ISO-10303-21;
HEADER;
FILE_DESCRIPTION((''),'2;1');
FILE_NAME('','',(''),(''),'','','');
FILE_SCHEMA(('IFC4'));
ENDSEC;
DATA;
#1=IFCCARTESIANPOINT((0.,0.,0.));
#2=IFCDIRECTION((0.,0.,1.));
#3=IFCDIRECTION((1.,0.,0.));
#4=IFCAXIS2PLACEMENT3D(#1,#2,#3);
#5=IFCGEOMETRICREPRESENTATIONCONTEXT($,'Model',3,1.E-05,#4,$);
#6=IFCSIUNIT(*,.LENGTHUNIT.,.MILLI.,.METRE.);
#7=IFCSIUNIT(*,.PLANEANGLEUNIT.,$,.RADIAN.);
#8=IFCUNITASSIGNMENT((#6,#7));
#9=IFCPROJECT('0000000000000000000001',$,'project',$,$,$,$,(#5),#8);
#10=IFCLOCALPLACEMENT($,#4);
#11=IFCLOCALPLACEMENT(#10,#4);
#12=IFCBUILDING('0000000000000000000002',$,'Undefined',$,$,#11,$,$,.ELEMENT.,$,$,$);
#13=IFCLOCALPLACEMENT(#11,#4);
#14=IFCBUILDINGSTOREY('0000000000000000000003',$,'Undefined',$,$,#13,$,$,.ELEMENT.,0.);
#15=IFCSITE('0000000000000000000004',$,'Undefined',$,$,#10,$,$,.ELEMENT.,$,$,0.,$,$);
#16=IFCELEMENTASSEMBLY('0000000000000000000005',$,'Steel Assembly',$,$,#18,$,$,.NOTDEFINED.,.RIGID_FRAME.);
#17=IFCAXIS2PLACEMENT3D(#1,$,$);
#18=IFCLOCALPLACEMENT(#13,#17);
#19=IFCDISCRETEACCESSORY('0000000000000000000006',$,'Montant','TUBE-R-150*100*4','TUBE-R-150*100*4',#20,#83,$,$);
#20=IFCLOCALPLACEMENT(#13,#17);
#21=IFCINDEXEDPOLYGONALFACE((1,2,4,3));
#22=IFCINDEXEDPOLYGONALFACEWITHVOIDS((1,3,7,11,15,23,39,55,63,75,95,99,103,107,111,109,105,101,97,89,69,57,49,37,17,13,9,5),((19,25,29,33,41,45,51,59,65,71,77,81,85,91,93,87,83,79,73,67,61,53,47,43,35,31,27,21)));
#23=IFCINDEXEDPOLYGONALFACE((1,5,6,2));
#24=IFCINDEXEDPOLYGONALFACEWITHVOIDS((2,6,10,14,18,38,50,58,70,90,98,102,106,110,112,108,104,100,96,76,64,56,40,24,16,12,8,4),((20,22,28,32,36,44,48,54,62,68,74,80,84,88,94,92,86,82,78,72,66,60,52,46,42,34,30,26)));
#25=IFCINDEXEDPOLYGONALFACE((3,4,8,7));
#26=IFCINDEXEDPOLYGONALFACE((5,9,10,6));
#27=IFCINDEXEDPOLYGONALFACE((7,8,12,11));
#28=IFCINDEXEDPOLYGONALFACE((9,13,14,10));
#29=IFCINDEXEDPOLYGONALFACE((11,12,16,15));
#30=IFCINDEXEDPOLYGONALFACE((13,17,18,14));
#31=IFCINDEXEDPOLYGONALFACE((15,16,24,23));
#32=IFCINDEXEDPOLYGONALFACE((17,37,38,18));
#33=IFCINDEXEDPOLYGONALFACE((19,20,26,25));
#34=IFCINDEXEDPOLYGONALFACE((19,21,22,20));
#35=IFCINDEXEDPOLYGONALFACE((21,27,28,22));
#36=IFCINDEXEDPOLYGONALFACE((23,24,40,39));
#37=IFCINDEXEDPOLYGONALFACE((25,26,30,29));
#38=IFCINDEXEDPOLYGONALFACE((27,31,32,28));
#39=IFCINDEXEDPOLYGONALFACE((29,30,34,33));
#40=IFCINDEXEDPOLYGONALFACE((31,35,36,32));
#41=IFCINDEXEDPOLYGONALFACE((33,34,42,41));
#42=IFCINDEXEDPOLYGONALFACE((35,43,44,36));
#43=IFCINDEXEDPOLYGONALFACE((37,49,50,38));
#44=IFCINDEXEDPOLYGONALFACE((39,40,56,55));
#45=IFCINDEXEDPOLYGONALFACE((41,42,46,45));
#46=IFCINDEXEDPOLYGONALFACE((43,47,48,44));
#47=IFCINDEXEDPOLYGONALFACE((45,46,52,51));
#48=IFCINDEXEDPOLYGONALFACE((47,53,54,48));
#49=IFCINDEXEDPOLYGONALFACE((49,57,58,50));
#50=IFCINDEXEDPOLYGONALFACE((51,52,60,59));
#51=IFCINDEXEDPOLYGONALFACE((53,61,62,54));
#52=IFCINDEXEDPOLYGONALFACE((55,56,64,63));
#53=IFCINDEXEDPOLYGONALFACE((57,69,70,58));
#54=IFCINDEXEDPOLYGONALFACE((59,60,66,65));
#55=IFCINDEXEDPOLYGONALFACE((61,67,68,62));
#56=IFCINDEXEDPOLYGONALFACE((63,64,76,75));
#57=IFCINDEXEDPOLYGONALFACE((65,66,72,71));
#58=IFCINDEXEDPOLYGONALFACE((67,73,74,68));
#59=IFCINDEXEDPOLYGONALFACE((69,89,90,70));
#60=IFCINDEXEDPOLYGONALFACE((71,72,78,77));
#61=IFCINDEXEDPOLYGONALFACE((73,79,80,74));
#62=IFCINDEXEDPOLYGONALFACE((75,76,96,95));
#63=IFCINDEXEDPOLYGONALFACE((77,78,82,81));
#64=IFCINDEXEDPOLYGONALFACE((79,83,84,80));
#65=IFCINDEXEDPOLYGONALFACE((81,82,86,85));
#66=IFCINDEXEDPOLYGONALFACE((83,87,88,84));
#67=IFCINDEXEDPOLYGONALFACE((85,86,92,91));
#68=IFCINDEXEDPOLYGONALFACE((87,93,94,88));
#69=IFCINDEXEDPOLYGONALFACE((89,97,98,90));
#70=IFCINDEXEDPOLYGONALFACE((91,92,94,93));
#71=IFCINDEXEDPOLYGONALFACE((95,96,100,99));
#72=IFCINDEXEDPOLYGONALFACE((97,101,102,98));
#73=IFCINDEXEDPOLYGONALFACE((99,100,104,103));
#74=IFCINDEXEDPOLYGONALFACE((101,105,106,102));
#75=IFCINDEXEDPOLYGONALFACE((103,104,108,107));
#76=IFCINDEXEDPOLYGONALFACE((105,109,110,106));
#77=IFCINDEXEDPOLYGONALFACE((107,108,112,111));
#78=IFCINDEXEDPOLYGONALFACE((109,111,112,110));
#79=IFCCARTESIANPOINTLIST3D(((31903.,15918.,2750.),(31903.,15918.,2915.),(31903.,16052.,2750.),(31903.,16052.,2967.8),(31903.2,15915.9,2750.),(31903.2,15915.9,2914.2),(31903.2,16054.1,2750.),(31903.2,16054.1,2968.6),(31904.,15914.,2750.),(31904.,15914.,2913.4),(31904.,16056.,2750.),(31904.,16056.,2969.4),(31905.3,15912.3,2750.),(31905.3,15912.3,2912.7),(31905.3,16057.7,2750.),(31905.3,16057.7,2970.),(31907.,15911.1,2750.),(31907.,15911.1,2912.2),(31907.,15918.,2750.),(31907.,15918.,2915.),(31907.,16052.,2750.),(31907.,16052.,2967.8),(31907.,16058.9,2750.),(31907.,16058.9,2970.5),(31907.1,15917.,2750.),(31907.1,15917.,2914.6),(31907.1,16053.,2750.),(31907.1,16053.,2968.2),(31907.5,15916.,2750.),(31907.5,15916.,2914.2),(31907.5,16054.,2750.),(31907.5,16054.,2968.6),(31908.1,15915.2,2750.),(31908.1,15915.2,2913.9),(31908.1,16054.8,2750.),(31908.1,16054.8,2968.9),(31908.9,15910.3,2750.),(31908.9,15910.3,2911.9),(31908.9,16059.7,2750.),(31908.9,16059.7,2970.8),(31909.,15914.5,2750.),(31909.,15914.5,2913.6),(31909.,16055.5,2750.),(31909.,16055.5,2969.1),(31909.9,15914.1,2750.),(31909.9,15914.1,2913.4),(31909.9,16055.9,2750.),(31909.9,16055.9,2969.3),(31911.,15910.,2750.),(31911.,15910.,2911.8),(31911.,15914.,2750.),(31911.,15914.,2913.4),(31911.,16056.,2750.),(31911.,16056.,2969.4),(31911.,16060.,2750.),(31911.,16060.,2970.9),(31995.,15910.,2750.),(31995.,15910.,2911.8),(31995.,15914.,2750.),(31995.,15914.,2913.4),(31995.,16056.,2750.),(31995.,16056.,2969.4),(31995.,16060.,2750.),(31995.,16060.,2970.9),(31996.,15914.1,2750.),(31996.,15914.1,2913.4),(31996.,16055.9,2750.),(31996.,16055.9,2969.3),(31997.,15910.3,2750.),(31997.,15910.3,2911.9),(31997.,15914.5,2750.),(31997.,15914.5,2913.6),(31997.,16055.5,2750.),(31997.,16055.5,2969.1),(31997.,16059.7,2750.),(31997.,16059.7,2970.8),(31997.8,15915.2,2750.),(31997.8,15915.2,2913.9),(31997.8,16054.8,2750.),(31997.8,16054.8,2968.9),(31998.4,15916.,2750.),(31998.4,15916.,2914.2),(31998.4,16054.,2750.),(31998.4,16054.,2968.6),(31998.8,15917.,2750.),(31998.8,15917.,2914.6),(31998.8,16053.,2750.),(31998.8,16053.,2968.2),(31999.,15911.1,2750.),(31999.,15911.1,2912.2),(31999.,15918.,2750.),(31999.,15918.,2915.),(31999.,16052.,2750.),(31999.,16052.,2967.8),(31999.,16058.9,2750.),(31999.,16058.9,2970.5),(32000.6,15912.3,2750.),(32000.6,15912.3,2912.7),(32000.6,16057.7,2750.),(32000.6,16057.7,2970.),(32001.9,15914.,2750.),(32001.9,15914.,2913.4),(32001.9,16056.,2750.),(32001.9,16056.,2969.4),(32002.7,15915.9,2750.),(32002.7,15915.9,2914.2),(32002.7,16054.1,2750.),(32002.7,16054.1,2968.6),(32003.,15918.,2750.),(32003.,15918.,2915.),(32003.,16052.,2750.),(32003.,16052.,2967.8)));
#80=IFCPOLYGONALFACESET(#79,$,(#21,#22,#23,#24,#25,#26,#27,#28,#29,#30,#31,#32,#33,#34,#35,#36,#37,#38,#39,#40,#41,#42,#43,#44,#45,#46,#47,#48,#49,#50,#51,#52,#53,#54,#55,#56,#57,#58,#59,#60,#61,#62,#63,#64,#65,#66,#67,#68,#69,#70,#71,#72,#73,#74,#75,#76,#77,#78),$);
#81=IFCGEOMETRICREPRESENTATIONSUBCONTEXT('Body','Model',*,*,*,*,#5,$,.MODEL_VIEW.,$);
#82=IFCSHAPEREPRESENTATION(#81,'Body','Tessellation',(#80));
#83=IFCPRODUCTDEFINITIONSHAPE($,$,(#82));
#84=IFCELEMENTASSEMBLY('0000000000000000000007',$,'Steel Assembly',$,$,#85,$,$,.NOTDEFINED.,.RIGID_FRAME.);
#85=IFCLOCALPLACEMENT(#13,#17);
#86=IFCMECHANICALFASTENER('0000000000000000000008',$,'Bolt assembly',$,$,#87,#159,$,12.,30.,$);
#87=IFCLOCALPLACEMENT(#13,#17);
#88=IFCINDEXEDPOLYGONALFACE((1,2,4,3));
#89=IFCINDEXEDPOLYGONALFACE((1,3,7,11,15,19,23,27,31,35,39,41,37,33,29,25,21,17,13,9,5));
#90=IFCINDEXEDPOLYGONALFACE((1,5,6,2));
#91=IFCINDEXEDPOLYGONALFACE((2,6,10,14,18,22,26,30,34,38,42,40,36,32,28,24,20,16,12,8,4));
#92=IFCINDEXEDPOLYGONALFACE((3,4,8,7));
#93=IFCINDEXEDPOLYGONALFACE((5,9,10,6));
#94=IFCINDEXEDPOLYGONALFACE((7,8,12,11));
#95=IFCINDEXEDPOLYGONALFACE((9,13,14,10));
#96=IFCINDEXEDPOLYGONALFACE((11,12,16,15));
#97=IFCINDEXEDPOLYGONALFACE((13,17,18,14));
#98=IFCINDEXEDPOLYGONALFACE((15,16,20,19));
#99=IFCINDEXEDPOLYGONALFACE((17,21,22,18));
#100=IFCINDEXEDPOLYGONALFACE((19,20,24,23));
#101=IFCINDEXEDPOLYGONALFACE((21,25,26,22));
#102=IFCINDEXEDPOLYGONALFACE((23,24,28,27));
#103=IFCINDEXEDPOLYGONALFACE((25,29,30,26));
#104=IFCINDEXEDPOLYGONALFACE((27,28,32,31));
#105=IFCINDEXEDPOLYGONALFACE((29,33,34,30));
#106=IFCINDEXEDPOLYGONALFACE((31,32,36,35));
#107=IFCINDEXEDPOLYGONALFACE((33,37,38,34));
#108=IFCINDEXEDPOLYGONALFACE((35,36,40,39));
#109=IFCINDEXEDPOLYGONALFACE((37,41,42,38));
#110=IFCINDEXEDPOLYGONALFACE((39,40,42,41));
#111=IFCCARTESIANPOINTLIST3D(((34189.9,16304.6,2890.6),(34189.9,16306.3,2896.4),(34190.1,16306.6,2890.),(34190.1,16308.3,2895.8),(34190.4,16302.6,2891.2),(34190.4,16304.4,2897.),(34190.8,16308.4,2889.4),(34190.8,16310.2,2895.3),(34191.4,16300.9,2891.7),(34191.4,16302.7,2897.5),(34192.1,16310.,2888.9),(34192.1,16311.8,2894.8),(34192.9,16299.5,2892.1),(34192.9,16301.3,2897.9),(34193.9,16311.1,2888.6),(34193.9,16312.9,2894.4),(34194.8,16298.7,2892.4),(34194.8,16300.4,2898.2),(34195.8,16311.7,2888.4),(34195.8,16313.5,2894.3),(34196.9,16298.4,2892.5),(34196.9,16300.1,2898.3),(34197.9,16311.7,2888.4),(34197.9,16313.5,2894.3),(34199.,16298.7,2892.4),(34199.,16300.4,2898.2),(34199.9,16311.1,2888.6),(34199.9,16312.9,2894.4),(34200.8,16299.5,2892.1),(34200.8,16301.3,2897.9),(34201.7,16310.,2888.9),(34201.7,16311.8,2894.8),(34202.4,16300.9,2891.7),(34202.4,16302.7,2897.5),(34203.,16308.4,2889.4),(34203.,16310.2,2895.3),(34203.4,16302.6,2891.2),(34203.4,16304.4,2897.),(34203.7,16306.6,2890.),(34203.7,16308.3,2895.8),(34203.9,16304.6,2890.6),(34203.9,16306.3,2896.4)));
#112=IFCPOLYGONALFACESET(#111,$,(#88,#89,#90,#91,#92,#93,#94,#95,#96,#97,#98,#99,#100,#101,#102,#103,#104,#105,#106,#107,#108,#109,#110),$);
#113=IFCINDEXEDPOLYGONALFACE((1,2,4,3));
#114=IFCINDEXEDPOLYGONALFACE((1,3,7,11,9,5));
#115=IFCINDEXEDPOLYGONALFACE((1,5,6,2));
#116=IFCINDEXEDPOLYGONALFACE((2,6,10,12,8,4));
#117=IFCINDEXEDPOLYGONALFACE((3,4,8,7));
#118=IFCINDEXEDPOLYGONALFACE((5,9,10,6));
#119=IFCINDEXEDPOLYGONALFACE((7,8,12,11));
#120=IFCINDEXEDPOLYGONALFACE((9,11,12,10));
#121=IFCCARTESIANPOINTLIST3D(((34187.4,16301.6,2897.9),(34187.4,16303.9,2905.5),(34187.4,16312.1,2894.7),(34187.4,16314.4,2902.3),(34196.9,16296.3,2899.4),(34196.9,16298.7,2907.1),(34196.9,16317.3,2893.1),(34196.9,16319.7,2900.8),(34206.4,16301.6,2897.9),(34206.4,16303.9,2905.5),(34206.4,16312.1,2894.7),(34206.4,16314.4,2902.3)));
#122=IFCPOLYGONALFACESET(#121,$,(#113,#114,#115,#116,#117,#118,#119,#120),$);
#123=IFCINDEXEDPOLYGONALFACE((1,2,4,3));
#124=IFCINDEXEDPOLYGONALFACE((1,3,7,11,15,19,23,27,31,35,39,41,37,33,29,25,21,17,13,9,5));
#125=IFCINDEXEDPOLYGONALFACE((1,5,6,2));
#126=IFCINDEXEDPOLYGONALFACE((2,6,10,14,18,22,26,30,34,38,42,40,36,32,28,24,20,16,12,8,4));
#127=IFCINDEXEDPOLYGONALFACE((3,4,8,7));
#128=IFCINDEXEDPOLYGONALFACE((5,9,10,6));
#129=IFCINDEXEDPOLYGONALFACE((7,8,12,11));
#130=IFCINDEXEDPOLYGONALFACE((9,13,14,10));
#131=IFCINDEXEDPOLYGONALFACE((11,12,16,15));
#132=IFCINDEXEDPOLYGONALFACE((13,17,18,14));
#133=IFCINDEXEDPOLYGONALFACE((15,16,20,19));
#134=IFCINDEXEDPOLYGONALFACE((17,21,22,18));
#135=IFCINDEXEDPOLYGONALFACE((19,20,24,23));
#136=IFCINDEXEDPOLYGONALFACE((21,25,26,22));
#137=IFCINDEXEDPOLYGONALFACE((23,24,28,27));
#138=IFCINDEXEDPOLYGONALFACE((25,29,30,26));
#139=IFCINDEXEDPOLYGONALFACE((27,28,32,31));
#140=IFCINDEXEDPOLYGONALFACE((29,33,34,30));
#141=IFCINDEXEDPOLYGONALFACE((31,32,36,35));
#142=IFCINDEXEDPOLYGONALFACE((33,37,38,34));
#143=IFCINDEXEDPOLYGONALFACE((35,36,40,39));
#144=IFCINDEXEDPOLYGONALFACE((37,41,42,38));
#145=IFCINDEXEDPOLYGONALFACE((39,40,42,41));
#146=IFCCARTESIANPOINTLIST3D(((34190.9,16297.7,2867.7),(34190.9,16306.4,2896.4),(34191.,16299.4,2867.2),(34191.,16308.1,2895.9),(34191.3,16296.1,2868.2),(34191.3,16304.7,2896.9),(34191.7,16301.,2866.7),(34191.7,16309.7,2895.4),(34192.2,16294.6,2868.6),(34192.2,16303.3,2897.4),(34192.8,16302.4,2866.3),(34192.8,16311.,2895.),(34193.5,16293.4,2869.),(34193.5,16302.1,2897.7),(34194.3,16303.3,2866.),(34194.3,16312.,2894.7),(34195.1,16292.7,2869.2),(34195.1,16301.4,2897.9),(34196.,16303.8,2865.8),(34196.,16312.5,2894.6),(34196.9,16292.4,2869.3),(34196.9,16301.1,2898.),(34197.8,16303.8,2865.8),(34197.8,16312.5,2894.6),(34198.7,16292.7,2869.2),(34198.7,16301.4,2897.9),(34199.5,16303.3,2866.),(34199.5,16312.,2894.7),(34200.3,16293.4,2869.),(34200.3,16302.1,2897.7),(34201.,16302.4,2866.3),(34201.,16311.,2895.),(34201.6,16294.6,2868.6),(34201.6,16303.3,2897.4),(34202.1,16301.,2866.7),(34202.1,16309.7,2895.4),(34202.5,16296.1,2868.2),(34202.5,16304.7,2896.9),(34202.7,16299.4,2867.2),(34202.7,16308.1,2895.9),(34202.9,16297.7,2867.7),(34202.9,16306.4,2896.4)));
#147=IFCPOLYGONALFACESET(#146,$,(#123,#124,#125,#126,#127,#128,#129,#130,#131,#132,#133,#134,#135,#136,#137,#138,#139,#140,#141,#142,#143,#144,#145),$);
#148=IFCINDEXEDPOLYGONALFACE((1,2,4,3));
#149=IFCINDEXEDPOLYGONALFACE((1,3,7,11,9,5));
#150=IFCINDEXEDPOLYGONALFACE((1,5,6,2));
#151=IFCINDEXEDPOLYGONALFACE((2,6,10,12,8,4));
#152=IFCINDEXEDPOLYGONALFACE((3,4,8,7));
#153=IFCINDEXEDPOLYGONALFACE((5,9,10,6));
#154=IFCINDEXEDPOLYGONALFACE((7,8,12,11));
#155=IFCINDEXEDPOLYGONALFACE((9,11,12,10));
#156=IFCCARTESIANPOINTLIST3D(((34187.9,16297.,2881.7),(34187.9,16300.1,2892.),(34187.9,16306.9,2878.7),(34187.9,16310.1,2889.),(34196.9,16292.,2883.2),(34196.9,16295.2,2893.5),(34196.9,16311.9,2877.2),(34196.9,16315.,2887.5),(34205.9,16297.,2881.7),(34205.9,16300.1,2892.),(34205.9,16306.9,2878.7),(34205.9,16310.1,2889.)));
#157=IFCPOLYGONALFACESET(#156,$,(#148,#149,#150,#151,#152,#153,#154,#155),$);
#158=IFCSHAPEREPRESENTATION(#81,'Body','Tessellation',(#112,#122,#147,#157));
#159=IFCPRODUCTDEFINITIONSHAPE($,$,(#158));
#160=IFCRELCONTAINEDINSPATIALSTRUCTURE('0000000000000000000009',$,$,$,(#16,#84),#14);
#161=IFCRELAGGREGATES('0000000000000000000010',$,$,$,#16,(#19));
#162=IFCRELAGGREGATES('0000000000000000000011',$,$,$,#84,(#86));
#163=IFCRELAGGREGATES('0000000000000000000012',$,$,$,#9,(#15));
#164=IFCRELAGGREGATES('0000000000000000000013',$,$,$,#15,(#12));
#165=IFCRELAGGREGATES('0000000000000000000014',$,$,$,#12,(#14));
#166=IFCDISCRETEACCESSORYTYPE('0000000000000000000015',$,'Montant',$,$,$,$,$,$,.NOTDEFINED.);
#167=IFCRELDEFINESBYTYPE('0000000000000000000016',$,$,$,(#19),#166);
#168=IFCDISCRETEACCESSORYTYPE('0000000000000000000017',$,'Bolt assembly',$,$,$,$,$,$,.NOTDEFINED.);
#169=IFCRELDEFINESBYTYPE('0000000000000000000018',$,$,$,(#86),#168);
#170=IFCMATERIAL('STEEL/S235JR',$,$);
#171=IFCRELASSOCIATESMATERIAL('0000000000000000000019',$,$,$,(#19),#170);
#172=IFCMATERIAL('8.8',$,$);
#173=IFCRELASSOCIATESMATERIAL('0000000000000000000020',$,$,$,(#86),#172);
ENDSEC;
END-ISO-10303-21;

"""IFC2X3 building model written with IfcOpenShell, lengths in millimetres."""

from ifc_helpers import new_model, si_unit, frame, origin_with_axes, origin_2d_with_axis, place, context, subcontext, project, spatial, polyline, hollow_rectangle, circle, outline, extrude, clip, halfspace, source, transform, mapped, material, type_object, element, aggregate, save


model = new_model("IFC2X3")

# Units and contexts
model_context = context("Model", 3, precision=1e-05, world=origin_with_axes())
body_context = subcontext(model_context, "Body", "Model", "MODEL_VIEW")
ifc_project = project(units=[si_unit("LENGTHUNIT", "METRE", prefix="MILLI"), si_unit("PLANEANGLEUNIT", "RADIAN")], contexts=[model_context])

# Site, building, storey
site_placement = place(None, origin_with_axes())
site = spatial("IfcSite", under=ifc_project, at=site_placement, Name="Undefined", CompositionType="ELEMENT", RefElevation=0.0)
building_placement = place(site_placement, origin_with_axes())
building = spatial("IfcBuilding", under=site, at=building_placement, Name="Undefined", CompositionType="ELEMENT")
storey_placement = place(building_placement, origin_with_axes())
storey = spatial("IfcBuildingStorey", under=building, at=storey_placement, Name="Undefined", CompositionType="ELEMENT", Elevation=0.0)

# Shared definitions
ifc_material_1 = material(Name="STEEL/S235JR")

# Shared definitions
discrete_accessory_type_1 = type_object("IfcDiscreteAccessoryType", Name="Bolt assembly")

# Element assembly
assembly_1_placement = place(storey_placement, origin_with_axes())
assembly_1 = element("IfcElementAssembly", 1, at=assembly_1_placement, inside=storey, Name="Steel Assembly", AssemblyPlace="NOTDEFINED", PredefinedType="RIGID_FRAME")
ifc_material_2 = material(Name="8.8")

# Discrete accessory
discrete_accessory_type_2 = type_object("IfcDiscreteAccessoryType", Name="Montant")
discrete_accessory_1_placement = place(assembly_1_placement, frame((31953.0, 15985.0, 3075.7), z_axis=(0.0, 1.0, 0.0), x_axis=(0.0, 0.0, -1.0)))
discrete_accessory_1 = element("IfcDiscreteAccessory", 2, at=discrete_accessory_1_placement, type_object=discrete_accessory_type_2, material=ifc_material_1, Name="Montant", Description="TUBE-R-150*100*4", ObjectType="TUBE-R-150*100*4", context=body_context, shape_type="Clipping", body=[
    clip(extrude(hollow_rectangle(XDim=100.0, YDim=150.0, WallThickness=4.0, InnerFilletRadius=4.0, OuterFilletRadius=8.0, at=origin_2d_with_axis()), frame((325.7, 0.0, 0.0), z_axis=(-1.0, 0.0, 0.0), x_axis=(0.0, -1.0, 0.0)), (0.0, 0.0, 1.0), 221.2), halfspace(frame((163.9, -50.0, -75.0), z_axis=(0.930375, 0.0, 0.366608), x_axis=(0.0, -1.0, 0.0)), True)),
])
aggregate(assembly_1, [discrete_accessory_1])

# Element assembly, mechanical fastener
assembly_2_placement = place(storey_placement, origin_with_axes())
assembly_2 = element("IfcElementAssembly", 3, at=assembly_2_placement, inside=storey, Name="Steel Assembly", AssemblyPlace="NOTDEFINED", PredefinedType="RIGID_FRAME")
shared_shape_1 = source(origin_with_axes(), body_context, "Body", "SweptSolid", [
    extrude(circle(Radius=7.0, at=origin_2d_with_axis()), frame((0.0, -6.0, 0.0), z_axis=(0.0, 1.0, 0.0), x_axis=(1.0, 0.0, 0.0)), (0.0, 0.0, 1.0), 6.1),
    extrude(outline(polyline([(11.0, 0.0), (5.5, 9.5), (-5.5, 9.5), (-11.0, 0.0), (-5.5, -9.5), (5.5, -9.5), (11.0, 0.0)])), frame((0.0, -14.0, 0.0), z_axis=(0.0, 1.0, 0.0), x_axis=(1.0, 0.0, 0.0)), (0.0, 0.0, 1.0), 8.0),
    extrude(circle(Radius=6.0, at=origin_2d_with_axis()), frame((0.0, -6.0, 0.0), z_axis=(0.0, 1.0, 0.0), x_axis=(1.0, 0.0, 0.0)), (0.0, 0.0, 1.0), 30.0),
    extrude(outline(polyline([(10.4, 0.0), (5.2, 9.0), (-5.2, 9.0), (-10.4, 0.0), (-5.2, -9.0), (5.2, -9.0), (10.4, 0.0)])), frame((0.0, 0.0, 0.0), z_axis=(0.0, 1.0, 0.0), x_axis=(1.0, 0.0, 0.0)), (0.0, 0.0, 1.0), 10.8),
])
mechanical_fastener_1_placement = place(assembly_2_placement, frame((34196.9, 16305.1, 2890.5), z_axis=(1.0, 0.0, 0.0), x_axis=(0.0, -0.957179, 0.289497)))
mechanical_fastener_1 = element("IfcMechanicalFastener", 4, at=mechanical_fastener_1_placement, type_object=discrete_accessory_type_1, material=ifc_material_2, Name="Bolt assembly", NominalDiameter=12.0, NominalLength=30.0, context=body_context, shape_type="MappedRepresentation", body=[
    mapped(shared_shape_1, transform((0.0, 0.0, 0.0))),
])
aggregate(assembly_2, [mechanical_fastener_1])

save(model, "model.ifc")
